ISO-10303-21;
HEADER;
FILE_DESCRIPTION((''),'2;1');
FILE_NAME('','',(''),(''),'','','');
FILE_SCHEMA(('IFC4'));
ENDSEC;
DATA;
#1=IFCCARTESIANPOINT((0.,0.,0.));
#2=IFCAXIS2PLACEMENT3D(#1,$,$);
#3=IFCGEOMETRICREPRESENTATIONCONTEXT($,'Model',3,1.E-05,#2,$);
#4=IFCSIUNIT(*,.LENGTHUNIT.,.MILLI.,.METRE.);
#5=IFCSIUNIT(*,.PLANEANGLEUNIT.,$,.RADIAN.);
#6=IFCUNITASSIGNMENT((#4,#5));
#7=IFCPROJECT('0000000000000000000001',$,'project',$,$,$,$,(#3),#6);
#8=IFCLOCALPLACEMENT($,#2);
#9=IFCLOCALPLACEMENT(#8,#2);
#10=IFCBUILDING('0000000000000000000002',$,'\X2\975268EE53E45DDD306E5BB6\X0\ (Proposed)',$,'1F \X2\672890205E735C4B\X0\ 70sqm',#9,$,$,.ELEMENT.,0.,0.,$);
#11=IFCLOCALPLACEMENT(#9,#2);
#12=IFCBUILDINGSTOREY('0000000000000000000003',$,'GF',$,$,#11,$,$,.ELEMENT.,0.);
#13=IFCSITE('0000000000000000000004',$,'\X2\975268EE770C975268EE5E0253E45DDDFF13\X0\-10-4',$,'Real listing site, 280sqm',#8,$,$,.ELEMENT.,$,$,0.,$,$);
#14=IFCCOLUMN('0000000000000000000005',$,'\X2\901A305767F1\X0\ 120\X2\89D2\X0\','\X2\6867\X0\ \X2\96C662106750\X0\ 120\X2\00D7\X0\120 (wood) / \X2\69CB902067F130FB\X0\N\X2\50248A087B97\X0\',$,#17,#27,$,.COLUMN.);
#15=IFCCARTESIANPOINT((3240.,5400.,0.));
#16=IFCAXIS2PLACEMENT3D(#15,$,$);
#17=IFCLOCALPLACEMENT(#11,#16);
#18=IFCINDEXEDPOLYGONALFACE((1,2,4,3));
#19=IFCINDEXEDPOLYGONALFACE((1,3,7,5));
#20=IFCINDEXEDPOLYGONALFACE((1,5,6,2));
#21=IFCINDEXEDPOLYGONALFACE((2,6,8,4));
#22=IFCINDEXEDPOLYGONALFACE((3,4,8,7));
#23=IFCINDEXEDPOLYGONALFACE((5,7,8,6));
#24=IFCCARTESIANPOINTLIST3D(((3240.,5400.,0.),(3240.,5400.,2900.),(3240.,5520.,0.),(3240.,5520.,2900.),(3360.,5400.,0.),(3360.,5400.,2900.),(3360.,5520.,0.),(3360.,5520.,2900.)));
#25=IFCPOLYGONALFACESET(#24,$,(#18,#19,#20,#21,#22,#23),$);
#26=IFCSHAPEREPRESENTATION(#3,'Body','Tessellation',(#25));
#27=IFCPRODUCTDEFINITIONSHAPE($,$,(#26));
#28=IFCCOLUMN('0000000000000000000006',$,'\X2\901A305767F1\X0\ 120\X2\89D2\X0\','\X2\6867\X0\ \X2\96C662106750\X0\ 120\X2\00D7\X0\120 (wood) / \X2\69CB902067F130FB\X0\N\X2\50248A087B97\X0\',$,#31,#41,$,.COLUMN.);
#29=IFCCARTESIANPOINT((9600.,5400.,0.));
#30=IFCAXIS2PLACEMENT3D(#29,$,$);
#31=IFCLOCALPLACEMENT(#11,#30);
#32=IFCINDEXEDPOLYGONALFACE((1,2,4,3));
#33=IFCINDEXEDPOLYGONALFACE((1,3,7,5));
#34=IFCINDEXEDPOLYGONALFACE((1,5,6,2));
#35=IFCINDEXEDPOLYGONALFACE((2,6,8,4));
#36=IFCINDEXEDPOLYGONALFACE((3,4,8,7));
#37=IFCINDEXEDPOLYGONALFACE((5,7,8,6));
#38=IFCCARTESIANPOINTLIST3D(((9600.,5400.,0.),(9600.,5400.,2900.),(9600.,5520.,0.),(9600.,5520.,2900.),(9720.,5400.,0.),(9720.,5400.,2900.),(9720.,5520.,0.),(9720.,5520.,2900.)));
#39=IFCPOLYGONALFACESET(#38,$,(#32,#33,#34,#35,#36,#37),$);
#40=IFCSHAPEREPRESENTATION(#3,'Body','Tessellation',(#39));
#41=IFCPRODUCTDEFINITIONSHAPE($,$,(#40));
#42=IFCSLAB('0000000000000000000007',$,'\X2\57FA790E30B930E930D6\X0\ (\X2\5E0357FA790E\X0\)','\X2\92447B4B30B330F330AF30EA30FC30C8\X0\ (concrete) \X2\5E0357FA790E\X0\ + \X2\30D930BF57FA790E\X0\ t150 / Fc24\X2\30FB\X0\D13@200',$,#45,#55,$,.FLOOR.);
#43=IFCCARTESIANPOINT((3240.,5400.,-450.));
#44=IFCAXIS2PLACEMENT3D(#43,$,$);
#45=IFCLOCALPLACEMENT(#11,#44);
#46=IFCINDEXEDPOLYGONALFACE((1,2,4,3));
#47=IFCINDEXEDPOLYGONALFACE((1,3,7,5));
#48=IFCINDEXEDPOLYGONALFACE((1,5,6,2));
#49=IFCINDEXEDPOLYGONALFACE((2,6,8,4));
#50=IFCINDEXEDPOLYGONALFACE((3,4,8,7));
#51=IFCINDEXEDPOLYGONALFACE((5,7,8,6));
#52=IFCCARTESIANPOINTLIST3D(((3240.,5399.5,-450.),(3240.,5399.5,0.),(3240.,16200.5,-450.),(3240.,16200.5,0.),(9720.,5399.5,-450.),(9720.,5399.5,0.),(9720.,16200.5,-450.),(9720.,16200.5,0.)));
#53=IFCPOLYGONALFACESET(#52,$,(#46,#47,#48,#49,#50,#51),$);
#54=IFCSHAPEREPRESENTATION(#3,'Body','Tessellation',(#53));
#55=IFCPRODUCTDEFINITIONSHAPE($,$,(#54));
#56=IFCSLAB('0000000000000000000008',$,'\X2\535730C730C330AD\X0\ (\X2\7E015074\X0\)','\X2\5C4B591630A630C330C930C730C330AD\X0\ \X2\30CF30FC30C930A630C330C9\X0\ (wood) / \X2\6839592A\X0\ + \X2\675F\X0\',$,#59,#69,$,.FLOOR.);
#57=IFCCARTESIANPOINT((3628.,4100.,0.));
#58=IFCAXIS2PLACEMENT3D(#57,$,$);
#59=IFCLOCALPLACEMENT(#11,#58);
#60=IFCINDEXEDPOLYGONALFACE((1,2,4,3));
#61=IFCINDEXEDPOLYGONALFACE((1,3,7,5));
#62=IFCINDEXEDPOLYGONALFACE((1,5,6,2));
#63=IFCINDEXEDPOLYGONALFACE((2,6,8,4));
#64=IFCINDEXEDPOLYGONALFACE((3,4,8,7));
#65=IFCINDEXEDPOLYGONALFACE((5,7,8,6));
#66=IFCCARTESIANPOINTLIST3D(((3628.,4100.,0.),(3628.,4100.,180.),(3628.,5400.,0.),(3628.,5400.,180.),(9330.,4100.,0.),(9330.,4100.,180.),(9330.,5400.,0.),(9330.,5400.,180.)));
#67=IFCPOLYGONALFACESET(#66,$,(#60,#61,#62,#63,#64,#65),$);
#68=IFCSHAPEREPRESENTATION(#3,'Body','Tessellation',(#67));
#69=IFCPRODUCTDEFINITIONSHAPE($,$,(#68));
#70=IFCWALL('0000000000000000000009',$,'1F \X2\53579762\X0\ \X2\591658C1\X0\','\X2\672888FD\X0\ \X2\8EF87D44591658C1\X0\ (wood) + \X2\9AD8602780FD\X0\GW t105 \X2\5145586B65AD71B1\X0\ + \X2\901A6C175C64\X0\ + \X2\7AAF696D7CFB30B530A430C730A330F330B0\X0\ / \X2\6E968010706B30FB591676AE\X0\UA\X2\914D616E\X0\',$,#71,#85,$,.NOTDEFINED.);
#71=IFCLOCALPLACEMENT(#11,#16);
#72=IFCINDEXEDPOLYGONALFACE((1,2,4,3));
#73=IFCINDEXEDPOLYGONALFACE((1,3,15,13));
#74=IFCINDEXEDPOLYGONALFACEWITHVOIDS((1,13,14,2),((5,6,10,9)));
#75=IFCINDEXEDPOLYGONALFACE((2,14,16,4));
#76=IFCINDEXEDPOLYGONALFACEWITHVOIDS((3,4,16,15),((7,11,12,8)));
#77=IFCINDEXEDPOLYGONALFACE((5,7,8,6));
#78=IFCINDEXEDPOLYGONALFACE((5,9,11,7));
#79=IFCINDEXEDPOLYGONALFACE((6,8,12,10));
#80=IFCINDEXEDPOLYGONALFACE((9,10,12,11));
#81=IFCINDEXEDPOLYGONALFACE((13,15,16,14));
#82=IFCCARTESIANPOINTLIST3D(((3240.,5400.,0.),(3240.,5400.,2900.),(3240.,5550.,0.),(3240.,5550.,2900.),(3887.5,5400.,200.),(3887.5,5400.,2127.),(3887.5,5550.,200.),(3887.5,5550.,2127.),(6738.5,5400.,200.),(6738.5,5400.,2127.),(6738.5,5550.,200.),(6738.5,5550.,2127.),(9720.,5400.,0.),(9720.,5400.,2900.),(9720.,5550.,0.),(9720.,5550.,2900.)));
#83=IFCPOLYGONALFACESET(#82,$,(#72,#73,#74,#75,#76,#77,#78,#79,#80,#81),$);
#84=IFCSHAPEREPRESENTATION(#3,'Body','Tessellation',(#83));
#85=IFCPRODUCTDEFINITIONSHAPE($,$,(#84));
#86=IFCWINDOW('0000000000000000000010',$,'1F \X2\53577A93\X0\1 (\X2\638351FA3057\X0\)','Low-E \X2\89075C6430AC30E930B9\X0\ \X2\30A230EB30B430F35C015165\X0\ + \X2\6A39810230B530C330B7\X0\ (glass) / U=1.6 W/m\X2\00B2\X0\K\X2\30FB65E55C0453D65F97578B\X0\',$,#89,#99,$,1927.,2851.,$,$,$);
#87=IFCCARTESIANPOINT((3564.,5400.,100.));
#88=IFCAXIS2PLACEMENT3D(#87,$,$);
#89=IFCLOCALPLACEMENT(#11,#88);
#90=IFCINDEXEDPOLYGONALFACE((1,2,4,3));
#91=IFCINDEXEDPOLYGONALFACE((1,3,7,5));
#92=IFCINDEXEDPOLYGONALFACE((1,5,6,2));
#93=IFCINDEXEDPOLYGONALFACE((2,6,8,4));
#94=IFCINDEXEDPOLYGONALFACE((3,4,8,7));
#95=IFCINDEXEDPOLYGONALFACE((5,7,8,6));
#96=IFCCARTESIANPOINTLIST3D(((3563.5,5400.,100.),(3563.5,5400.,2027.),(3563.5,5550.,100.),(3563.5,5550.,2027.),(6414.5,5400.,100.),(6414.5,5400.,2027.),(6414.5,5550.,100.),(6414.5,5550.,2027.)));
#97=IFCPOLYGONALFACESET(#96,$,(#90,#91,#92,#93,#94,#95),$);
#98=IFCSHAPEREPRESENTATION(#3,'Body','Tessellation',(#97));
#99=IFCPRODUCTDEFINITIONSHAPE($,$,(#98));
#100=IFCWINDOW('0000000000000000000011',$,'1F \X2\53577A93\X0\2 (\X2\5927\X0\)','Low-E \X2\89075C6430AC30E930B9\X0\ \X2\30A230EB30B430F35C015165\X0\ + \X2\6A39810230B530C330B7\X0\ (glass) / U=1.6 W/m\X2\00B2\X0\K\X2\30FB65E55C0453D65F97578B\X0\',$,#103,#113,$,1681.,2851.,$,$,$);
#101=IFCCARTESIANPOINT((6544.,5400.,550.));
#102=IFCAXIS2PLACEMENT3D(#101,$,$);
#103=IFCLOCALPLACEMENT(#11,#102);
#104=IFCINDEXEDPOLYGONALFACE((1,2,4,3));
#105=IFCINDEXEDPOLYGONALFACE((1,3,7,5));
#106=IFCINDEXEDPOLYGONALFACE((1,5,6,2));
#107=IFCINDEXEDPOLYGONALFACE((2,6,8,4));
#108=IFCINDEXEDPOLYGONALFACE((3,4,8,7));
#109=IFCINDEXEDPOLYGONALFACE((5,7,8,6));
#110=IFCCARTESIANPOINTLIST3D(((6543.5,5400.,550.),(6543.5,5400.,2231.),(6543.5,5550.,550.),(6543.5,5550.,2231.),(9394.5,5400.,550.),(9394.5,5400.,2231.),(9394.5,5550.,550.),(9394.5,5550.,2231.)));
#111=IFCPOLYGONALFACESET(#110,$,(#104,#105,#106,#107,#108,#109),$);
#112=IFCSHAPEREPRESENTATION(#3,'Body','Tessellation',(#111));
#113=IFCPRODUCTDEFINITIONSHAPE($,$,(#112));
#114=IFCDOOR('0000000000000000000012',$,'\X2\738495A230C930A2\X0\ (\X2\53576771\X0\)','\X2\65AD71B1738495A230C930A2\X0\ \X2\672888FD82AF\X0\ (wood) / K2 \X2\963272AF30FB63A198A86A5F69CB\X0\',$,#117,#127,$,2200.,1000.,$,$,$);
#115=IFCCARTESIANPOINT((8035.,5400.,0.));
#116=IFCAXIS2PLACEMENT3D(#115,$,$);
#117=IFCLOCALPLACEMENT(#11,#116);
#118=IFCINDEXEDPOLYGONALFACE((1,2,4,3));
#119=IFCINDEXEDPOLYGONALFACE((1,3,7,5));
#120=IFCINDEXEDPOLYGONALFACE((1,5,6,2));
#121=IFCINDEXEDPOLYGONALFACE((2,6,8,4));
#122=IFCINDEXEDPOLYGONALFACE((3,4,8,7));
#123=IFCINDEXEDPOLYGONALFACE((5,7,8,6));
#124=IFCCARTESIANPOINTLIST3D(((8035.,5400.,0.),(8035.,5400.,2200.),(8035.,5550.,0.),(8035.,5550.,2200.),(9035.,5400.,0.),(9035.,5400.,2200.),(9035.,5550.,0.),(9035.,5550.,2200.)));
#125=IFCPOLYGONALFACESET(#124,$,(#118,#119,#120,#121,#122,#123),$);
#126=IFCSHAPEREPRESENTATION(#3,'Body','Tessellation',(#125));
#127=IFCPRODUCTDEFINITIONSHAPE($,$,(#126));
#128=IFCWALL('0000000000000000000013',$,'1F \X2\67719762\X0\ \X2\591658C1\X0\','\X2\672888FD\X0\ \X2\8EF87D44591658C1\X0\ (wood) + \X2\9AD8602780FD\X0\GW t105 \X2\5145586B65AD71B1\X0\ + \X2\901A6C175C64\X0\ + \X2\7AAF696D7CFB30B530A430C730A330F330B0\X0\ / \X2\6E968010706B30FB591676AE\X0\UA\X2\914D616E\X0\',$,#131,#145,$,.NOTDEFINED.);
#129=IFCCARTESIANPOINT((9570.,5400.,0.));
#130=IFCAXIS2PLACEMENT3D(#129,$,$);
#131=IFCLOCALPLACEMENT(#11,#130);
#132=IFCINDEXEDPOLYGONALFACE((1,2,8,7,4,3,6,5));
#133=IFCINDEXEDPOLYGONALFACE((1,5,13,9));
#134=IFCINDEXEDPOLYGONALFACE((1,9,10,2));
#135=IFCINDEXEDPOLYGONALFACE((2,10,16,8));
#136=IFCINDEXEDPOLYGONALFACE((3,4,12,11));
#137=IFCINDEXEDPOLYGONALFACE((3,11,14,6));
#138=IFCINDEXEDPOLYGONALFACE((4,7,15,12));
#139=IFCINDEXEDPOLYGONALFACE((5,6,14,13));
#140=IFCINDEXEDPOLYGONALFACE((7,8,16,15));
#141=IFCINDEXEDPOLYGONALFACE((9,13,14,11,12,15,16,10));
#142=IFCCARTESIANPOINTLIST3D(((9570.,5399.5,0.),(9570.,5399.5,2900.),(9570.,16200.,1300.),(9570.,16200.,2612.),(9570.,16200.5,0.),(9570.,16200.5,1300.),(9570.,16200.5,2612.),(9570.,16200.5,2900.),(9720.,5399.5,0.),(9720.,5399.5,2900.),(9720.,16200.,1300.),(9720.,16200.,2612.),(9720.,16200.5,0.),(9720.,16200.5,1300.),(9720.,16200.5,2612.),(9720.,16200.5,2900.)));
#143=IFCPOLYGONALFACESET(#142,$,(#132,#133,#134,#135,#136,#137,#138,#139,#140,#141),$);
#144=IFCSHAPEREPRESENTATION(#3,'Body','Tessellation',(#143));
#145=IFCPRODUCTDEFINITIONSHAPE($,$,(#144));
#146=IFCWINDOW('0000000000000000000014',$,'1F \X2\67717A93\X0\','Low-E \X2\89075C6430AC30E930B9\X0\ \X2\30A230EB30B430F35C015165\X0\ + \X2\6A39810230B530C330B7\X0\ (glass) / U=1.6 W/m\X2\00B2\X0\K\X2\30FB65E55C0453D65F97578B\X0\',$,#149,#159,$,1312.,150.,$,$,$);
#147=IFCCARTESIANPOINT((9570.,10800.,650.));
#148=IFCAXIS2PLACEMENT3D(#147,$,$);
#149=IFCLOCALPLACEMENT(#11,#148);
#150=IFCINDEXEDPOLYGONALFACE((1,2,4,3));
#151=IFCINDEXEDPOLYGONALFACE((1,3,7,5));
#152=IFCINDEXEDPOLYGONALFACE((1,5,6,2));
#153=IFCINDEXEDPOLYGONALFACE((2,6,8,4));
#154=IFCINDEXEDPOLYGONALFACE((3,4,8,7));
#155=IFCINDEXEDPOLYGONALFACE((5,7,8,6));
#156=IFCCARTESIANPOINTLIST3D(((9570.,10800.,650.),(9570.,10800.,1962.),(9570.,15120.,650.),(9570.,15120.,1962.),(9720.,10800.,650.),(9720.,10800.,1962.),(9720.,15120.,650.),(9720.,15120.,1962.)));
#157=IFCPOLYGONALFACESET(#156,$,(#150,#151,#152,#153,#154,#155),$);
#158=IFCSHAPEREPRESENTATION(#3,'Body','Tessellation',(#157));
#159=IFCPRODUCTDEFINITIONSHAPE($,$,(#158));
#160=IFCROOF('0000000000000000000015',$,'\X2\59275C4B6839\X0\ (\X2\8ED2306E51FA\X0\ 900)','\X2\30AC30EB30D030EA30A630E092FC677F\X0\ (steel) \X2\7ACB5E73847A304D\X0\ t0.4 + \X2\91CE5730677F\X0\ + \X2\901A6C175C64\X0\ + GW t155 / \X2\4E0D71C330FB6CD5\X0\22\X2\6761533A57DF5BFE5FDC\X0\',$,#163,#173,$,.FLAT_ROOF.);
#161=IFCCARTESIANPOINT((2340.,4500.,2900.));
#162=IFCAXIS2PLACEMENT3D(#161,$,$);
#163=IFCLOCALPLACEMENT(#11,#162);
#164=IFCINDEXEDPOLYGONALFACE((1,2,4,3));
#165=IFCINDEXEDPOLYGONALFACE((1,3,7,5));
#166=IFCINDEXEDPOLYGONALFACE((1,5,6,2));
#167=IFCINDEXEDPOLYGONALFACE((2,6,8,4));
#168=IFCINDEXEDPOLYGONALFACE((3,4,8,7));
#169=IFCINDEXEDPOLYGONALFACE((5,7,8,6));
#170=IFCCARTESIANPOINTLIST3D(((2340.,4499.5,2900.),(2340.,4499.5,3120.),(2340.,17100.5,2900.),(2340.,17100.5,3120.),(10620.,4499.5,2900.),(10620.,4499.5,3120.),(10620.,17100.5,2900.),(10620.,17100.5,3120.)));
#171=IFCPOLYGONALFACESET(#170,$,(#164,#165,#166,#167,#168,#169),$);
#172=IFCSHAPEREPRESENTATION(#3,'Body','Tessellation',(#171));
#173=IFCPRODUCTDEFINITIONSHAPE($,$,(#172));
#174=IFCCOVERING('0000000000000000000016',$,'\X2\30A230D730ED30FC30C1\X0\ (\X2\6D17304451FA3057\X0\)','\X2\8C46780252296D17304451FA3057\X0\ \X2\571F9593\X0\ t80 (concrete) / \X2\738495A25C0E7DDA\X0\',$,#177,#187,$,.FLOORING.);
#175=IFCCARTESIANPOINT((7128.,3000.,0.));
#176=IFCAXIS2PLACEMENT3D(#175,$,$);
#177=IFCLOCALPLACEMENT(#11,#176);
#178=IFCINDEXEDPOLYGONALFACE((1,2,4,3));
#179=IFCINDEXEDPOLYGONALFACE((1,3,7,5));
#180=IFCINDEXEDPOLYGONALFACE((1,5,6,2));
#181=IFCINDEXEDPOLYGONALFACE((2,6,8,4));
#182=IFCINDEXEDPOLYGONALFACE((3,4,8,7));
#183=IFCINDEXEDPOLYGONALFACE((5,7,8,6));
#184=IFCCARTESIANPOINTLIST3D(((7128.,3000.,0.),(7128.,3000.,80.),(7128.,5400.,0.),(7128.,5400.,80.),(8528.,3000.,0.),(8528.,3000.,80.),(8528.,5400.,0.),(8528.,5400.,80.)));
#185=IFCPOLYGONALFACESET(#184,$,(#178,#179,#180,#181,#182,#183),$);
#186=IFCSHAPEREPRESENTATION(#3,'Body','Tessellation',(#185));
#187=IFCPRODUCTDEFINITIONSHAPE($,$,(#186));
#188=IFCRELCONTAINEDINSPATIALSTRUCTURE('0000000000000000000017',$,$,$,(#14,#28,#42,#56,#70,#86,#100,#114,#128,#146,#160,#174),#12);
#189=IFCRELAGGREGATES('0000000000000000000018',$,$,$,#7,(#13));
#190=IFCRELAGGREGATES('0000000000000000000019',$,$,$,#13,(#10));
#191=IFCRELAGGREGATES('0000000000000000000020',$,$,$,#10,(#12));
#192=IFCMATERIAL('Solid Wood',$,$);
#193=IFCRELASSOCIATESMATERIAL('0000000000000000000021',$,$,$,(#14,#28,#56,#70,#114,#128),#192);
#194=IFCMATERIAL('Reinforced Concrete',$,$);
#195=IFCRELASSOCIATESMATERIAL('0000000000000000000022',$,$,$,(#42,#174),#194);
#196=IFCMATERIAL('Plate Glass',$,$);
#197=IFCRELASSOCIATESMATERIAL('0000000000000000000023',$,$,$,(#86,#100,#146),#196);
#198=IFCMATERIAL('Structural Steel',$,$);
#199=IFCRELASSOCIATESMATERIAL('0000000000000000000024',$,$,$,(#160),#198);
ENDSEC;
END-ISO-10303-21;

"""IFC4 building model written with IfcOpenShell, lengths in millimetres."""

from ifc_helpers import new_model, si_unit, frame, frame_2d, origin, place, context, project, spatial, rectangle, extrude, material, element, fill, save


model = new_model("IFC4")

# Units and contexts
model_context = context("Model", 3, precision=1e-05, world=origin())
ifc_project = project(units=[si_unit("LENGTHUNIT", "METRE", prefix="MILLI"), si_unit("PLANEANGLEUNIT", "RADIAN")], contexts=[model_context])

# Site, building, storey
site_placement = place(None, origin())
site = spatial("IfcSite", under=ifc_project, at=site_placement, Name="青森県青森市古川３-10-4", ObjectType="Real listing site, 280sqm", CompositionType="ELEMENT", RefElevation=0.0)
building_placement = place(site_placement, origin())
building = spatial("IfcBuilding", under=site, at=building_placement, Name="青森古川の家 (Proposed)", ObjectType="1F 木造平屋 70sqm", CompositionType="ELEMENT", ElevationOfRefHeight=0.0, ElevationOfTerrain=0.0)
storey_placement = place(building_placement, origin())
storey = spatial("IfcBuildingStorey", under=building, at=storey_placement, Name="GF", CompositionType="ELEMENT", Elevation=0.0)

# Columns
ifc_material_1 = material(Name="Solid Wood")
column_1_placement = place(storey_placement, frame((3240.0, 5400.0, 0.0)))
element("IfcColumn", 1, at=column_1_placement, inside=storey, material=ifc_material_1, Name="通し柱 120角", Description="桧 集成材 120×120 (wood) / 構造柱・N値計算", PredefinedType="COLUMN", context=model_context, shape_type="SweptSolid", body=[
    extrude(rectangle(XDim=120.0, YDim=120.0, at=frame_2d((60.0, 60.0))), frame((3240.0, 5400.0, 0.0)), (0.0, 0.0, 1.0), 2900.0),
])
column_2_placement = place(storey_placement, frame((9600.0, 5400.0, 0.0)))
element("IfcColumn", 2, at=column_2_placement, inside=storey, material=ifc_material_1, Name="通し柱 120角", Description="桧 集成材 120×120 (wood) / 構造柱・N値計算", PredefinedType="COLUMN", context=model_context, shape_type="SweptSolid", body=[
    extrude(rectangle(XDim=120.0, YDim=120.0, at=frame_2d((60.0, 60.0))), frame((9600.0, 5400.0, 0.0)), (0.0, 0.0, 1.0), 2900.0),
])

# Slabs
ifc_material_2 = material(Name="Reinforced Concrete")
slab_1_placement = place(storey_placement, frame((3240.0, 5400.0, -450.0)))
element("IfcSlab", 3, at=slab_1_placement, inside=storey, material=ifc_material_2, Name="基礎スラブ (布基礎)", Description="鉄筋コンクリート (concrete) 布基礎 + ベタ基礎 t150 / Fc24・D13@200", PredefinedType="FLOOR", context=model_context, shape_type="SweptSolid", body=[
    extrude(rectangle(XDim=6480.0, YDim=10801.0, at=frame_2d((3240.0, 5400.0))), frame((3240.0, 5400.0, -450.0)), (0.0, 0.0, 1.0), 450.0),
])
slab_2_placement = place(storey_placement, frame((3628.0, 4100.0, 0.0)))
element("IfcSlab", 4, at=slab_2_placement, inside=storey, material=ifc_material_1, Name="南デッキ (縁側)", Description="屋外ウッドデッキ ハードウッド (wood) / 根太 + 束", PredefinedType="FLOOR", context=model_context, shape_type="SweptSolid", body=[
    extrude(rectangle(XDim=5702.0, YDim=1300.0, at=frame_2d((2851.0, 650.0))), frame((3628.0, 4100.0, 0.0)), (0.0, 0.0, 1.0), 180.0),
])

# Wall, openings, windows, door
wall_1_placement = place(storey_placement, frame((3240.0, 5400.0, 0.0)))
wall_1 = element("IfcWall", 5, at=wall_1_placement, inside=storey, material=ifc_material_1, Name="1F 南面 外壁", Description="木製 軸組外壁 (wood) + 高性能GW t105 充填断熱 + 通気層 + 窯業系サイディング / 準耐火・外皮UA配慮", PredefinedType="NOTDEFINED", context=model_context, shape_type="SweptSolid", body=[
    extrude(rectangle(XDim=6480.0, YDim=150.0, at=frame_2d((3240.0, 75.0))), frame((3240.0, 5400.0, 0.0)), (0.0, 0.0, 1.0), 2900.0),
])
opening_1_placement = place(storey_placement, frame((3564.0, 5400.0, 100.0)))
opening_1 = element("IfcOpeningElement", 6, at=opening_1_placement, cuts=wall_1, PredefinedType="NOTDEFINED", context=model_context, shape_type="SweptSolid", body=[
    extrude(rectangle(XDim=2851.0, YDim=150.0, at=frame_2d((1425.0, 75.0))), frame((3564.0, 5400.0, 100.0)), (0.0, 0.0, 1.0), 1927.0),
])
opening_2_placement = place(storey_placement, frame((6544.0, 5400.0, 550.0)))
opening_2 = element("IfcOpeningElement", 7, at=opening_2_placement, cuts=wall_1, PredefinedType="NOTDEFINED", context=model_context, shape_type="SweptSolid", body=[
    extrude(rectangle(XDim=2851.0, YDim=150.0, at=frame_2d((1425.0, 75.0))), frame((6544.0, 5400.0, 550.0)), (0.0, 0.0, 1.0), 1681.0),
])
opening_3_placement = place(storey_placement, frame((8035.0, 5400.0, 0.0)))
opening_3 = element("IfcOpeningElement", 8, at=opening_3_placement, cuts=wall_1, PredefinedType="NOTDEFINED", context=model_context, shape_type="SweptSolid", body=[
    extrude(rectangle(XDim=1000.0, YDim=150.0, at=frame_2d((500.0, 75.0))), frame((8035.0, 5400.0, 0.0)), (0.0, 0.0, 1.0), 2200.0),
])
ifc_material_3 = material(Name="Plate Glass")
window_1_placement = place(storey_placement, frame((3564.0, 5400.0, 100.0)))
window_1 = element("IfcWindow", 9, at=window_1_placement, inside=storey, material=ifc_material_3, Name="1F 南窓1 (掃出し)", Description="Low-E 複層ガラス アルゴン封入 + 樹脂サッシ (glass) / U=1.6 W/m²K・日射取得型", OverallHeight=1927.0, OverallWidth=2851.0, context=model_context, shape_type="SweptSolid", body=[
    extrude(rectangle(XDim=2851.0, YDim=150.0, at=frame_2d((1425.0, 75.0))), frame((3564.0, 5400.0, 100.0)), (0.0, 0.0, 1.0), 1927.0),
])
fill(opening_1, window_1)
window_2_placement = place(storey_placement, frame((6544.0, 5400.0, 550.0)))
window_2 = element("IfcWindow", 10, at=window_2_placement, inside=storey, material=ifc_material_3, Name="1F 南窓2 (大)", Description="Low-E 複層ガラス アルゴン封入 + 樹脂サッシ (glass) / U=1.6 W/m²K・日射取得型", OverallHeight=1681.0, OverallWidth=2851.0, context=model_context, shape_type="SweptSolid", body=[
    extrude(rectangle(XDim=2851.0, YDim=150.0, at=frame_2d((1425.0, 75.0))), frame((6544.0, 5400.0, 550.0)), (0.0, 0.0, 1.0), 1681.0),
])
fill(opening_2, window_2)
door_placement = place(storey_placement, frame((8035.0, 5400.0, 0.0)))
door = element("IfcDoor", 11, at=door_placement, inside=storey, material=ifc_material_1, Name="玄関ドア (南東)", Description="断熱玄関ドア 木製芯 (wood) / K2 防犯・採風機構", OverallHeight=2200.0, OverallWidth=1000.0, context=model_context, shape_type="SweptSolid", body=[
    extrude(rectangle(XDim=1000.0, YDim=150.0, at=frame_2d((500.0, 75.0))), frame((8035.0, 5400.0, 0.0)), (0.0, 0.0, 1.0), 2200.0),
])
fill(opening_3, door)

# Wall, opening, window
wall_2_placement = place(storey_placement, frame((9570.0, 5400.0, 0.0)))
wall_2 = element("IfcWall", 12, at=wall_2_placement, inside=storey, material=ifc_material_1, Name="1F 東面 外壁", Description="木製 軸組外壁 (wood) + 高性能GW t105 充填断熱 + 通気層 + 窯業系サイディング / 準耐火・外皮UA配慮", PredefinedType="NOTDEFINED", context=model_context, shape_type="SweptSolid", body=[
    extrude(rectangle(XDim=150.0, YDim=10801.0, at=frame_2d((75.0, 5400.0))), frame((9570.0, 5400.0, 0.0)), (0.0, 0.0, 1.0), 2900.0),
])
opening_4_placement = place(storey_placement, frame((9570.0, 10800.0, 650.0)))
opening_4 = element("IfcOpeningElement", 13, at=opening_4_placement, cuts=wall_2, PredefinedType="NOTDEFINED", context=model_context, shape_type="SweptSolid", body=[
    extrude(rectangle(XDim=150.0, YDim=4320.0, at=frame_2d((75.0, 2160.0))), frame((9570.0, 10800.0, 650.0)), (0.0, 0.0, 1.0), 1312.0),
])
window_3_placement = place(storey_placement, frame((9570.0, 10800.0, 650.0)))
window_3 = element("IfcWindow", 14, at=window_3_placement, inside=storey, material=ifc_material_3, Name="1F 東窓", Description="Low-E 複層ガラス アルゴン封入 + 樹脂サッシ (glass) / U=1.6 W/m²K・日射取得型", OverallHeight=1312.0, OverallWidth=150.0, context=model_context, shape_type="SweptSolid", body=[
    extrude(rectangle(XDim=150.0, YDim=4320.0, at=frame_2d((75.0, 2160.0))), frame((9570.0, 10800.0, 650.0)), (0.0, 0.0, 1.0), 1312.0),
])
fill(opening_4, window_3)

# Roof
ifc_material_4 = material(Name="Structural Steel")
roof_placement = place(storey_placement, frame((2340.0, 4500.0, 2900.0)))
element("IfcRoof", 15, at=roof_placement, inside=storey, material=ifc_material_4, Name="大屋根 (軒の出 900)", Description="ガルバリウム鋼板 (steel) 立平葺き t0.4 + 野地板 + 通気層 + GW t155 / 不燃・法22条区域対応", PredefinedType="FLAT_ROOF", context=model_context, shape_type="SweptSolid", body=[
    extrude(rectangle(XDim=8280.0, YDim=12601.0, at=frame_2d((4140.0, 6300.0))), frame((2340.0, 4500.0, 2900.0)), (0.0, 0.0, 1.0), 220.0),
])

# Covering
covering_1_placement = place(storey_placement, frame((7128.0, 3000.0, 0.0)))
element("IfcCovering", 16, at=covering_1_placement, inside=storey, material=ifc_material_2, Name="アプローチ (洗い出し)", Description="豆砂利洗い出し 土間 t80 (concrete) / 玄関導線", PredefinedType="FLOORING", context=model_context, shape_type="SweptSolid", body=[
    extrude(rectangle(XDim=1400.0, YDim=2400.0, at=frame_2d((700.0, 1200.0))), frame((7128.0, 3000.0, 0.0)), (0.0, 0.0, 1.0), 80.0),
])

save(model, "model.ifc")
